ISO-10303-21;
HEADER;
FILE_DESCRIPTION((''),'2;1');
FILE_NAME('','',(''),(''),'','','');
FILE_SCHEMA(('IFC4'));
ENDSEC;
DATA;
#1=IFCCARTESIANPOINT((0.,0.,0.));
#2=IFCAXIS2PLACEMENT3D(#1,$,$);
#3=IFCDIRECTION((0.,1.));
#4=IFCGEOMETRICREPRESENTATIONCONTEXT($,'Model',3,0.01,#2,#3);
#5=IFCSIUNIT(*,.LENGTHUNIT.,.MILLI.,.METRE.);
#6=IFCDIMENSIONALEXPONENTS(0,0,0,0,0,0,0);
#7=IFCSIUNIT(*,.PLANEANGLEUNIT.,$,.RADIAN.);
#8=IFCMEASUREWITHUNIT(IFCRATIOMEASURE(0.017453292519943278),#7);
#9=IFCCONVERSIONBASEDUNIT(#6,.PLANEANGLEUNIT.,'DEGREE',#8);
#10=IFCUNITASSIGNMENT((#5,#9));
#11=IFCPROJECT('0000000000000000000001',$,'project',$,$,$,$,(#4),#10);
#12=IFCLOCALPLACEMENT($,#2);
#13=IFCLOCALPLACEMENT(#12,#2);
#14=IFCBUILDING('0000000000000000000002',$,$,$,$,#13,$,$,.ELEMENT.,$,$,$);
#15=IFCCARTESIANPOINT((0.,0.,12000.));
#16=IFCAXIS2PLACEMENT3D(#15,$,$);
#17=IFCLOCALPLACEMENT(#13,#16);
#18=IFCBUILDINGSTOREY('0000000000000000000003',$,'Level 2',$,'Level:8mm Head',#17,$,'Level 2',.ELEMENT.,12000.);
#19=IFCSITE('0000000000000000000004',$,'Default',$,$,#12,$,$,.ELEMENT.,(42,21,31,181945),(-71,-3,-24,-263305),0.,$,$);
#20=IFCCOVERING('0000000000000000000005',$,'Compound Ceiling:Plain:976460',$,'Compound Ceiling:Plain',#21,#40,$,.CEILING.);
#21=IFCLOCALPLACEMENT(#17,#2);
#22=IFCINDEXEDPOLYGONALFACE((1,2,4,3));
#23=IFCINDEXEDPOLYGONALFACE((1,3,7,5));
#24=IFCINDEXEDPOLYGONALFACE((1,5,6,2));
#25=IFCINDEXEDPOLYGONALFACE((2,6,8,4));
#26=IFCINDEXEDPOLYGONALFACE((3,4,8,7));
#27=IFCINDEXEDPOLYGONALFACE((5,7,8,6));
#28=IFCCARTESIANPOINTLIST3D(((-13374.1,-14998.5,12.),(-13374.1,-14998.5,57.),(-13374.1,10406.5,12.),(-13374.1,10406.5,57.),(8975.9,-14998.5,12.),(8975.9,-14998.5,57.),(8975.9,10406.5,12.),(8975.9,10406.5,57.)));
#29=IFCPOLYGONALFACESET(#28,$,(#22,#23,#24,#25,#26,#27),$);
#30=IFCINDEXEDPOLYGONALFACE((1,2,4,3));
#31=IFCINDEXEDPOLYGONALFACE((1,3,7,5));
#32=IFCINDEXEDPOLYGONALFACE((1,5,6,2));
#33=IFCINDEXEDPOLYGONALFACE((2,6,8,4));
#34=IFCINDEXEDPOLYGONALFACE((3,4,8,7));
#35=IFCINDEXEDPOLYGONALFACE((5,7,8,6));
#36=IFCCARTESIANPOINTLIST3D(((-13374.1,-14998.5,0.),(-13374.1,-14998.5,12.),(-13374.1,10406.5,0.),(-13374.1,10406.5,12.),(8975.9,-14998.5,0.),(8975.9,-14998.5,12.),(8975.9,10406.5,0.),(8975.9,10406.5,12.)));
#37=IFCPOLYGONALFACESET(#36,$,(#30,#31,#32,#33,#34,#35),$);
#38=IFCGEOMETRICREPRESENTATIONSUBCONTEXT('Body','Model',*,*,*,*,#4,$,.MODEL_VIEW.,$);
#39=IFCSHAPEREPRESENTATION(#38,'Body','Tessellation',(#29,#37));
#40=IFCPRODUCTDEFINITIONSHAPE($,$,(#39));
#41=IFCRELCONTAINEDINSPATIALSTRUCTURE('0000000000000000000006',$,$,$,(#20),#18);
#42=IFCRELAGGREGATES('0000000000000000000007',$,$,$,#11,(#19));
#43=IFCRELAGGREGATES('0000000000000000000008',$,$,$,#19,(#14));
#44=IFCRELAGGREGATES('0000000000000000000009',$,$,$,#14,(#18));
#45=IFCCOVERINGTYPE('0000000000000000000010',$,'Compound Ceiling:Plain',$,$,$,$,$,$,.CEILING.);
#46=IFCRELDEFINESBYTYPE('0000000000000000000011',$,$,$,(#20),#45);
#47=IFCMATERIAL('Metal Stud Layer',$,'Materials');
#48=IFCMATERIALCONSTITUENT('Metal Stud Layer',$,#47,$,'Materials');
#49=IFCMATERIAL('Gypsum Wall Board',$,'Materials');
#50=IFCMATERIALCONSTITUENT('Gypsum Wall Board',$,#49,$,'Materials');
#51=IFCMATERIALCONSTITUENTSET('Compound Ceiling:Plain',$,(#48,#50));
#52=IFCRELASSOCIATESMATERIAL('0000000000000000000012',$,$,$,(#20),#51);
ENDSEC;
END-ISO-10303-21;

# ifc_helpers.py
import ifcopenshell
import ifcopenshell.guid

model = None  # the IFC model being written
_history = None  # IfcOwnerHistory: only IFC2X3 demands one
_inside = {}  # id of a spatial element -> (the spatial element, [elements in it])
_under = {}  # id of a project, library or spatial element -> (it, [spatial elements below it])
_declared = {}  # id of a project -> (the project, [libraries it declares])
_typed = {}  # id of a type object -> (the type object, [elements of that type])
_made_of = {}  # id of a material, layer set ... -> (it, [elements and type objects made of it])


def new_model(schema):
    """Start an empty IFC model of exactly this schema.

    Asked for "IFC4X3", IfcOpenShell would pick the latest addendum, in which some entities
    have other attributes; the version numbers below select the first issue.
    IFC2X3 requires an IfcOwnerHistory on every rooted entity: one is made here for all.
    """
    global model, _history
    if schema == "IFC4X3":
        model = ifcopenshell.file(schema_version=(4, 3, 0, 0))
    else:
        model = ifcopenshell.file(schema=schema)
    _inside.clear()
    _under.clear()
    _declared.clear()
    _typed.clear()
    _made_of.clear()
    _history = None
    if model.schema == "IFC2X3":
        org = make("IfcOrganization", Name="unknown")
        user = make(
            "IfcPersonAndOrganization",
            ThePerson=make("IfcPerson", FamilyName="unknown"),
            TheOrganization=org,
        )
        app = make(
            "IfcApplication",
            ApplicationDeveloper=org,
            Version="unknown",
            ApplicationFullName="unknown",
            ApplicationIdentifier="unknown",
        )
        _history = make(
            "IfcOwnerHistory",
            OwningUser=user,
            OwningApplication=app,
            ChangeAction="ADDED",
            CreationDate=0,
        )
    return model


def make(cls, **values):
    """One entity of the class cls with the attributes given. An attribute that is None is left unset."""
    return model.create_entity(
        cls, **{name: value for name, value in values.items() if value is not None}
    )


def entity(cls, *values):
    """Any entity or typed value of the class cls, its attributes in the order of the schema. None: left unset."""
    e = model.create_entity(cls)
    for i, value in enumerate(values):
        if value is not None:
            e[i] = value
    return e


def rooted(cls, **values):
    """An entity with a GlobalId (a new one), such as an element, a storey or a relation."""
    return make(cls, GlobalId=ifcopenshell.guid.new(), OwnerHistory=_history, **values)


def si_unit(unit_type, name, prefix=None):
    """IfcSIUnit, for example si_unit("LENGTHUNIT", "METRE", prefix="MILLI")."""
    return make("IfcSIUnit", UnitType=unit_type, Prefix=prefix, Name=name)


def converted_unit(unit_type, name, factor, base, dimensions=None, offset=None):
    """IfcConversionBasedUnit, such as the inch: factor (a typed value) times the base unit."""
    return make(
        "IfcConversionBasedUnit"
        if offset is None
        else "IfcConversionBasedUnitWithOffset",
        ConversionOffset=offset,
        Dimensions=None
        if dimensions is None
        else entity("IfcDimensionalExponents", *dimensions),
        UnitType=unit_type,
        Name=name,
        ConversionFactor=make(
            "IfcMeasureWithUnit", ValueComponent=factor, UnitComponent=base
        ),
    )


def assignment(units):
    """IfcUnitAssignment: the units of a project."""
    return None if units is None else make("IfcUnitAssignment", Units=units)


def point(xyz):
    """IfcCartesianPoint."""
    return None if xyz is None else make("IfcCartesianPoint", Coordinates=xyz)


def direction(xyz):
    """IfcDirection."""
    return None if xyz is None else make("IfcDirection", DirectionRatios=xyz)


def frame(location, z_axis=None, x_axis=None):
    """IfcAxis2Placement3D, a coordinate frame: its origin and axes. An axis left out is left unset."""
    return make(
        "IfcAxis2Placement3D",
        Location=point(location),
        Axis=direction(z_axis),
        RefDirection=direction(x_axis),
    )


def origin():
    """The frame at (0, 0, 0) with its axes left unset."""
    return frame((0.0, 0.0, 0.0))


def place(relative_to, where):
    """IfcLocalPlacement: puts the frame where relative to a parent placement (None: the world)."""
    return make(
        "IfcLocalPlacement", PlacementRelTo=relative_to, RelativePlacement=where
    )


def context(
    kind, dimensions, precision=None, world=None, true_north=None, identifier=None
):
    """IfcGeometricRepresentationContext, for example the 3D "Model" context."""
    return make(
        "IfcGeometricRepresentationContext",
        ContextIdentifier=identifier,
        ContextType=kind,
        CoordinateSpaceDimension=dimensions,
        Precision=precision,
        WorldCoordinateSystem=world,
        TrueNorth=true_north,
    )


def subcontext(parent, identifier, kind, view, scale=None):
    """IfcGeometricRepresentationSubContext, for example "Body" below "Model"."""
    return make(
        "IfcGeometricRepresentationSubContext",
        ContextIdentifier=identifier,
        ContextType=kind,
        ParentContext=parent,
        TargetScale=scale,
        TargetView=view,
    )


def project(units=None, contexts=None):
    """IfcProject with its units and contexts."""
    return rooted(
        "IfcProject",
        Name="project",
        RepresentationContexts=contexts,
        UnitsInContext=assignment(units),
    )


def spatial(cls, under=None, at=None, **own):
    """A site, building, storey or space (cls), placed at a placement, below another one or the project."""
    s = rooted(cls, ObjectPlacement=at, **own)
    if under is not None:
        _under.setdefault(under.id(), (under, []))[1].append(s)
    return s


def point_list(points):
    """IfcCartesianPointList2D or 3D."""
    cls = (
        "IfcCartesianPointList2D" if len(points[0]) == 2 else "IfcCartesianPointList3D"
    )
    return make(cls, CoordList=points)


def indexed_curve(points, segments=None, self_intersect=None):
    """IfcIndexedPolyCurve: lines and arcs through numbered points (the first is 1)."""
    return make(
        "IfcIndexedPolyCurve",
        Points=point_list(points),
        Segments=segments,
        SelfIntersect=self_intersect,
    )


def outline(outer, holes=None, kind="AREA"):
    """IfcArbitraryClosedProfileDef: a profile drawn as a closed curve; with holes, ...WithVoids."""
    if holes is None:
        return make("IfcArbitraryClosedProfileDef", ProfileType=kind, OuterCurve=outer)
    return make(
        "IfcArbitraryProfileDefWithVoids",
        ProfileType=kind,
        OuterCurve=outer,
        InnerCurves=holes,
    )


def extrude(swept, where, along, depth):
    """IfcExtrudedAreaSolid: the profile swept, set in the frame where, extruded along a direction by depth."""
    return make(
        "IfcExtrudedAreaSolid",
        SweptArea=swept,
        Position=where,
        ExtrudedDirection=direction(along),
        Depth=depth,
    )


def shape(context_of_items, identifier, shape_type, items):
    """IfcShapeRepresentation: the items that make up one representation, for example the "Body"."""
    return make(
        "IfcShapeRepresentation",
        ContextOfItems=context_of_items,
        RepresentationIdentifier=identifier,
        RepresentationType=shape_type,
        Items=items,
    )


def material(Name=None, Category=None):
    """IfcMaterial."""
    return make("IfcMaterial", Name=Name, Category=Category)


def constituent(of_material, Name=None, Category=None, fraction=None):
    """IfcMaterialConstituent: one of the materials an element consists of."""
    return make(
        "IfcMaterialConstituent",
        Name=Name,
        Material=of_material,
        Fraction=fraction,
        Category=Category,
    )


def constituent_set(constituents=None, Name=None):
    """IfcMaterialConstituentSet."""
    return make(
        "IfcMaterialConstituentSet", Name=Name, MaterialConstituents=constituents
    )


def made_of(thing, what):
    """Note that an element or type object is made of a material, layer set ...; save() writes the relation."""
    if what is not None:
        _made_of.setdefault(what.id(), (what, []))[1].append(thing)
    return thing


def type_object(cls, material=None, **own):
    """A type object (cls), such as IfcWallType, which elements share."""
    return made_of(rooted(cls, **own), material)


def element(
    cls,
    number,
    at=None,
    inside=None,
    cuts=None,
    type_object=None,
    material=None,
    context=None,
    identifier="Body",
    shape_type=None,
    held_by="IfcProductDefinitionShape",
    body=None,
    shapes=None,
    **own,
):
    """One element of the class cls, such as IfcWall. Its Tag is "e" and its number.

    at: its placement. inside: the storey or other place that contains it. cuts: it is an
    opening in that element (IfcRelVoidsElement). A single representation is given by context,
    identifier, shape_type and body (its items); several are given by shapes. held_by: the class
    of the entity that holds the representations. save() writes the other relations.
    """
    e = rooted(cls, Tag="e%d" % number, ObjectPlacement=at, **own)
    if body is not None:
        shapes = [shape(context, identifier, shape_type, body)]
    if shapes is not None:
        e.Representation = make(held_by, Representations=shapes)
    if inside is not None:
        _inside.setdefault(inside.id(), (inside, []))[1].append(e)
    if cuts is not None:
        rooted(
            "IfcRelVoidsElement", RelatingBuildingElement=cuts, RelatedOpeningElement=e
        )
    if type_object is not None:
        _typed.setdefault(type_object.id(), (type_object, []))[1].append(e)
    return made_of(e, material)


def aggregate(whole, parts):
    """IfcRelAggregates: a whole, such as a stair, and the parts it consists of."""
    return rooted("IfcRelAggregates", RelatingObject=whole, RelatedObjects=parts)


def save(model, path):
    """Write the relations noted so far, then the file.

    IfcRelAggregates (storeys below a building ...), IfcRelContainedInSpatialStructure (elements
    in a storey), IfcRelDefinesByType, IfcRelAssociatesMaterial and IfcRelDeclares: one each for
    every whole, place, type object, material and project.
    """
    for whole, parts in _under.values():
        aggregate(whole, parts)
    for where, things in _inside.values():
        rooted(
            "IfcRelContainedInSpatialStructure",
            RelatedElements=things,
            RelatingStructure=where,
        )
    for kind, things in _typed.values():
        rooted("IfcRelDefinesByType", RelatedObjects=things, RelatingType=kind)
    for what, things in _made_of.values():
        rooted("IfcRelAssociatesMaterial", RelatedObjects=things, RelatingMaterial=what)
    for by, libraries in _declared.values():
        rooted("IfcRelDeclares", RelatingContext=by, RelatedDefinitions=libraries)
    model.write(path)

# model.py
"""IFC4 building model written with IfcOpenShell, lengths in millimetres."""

from ifc_helpers import new_model, entity, si_unit, converted_unit, direction, frame, origin, place, context, subcontext, project, spatial, indexed_curve, outline, extrude, material, constituent, constituent_set, type_object, element, save


model = new_model("IFC4")

# Units and contexts
model_context = context("Model", 3, precision=0.01, world=origin(), true_north=direction((0.0, 1.0)))
body_context = subcontext(model_context, "Body", "Model", "MODEL_VIEW")
ifc_project = project(units=[si_unit("LENGTHUNIT", "METRE", prefix="MILLI"), converted_unit("PLANEANGLEUNIT", "DEGREE", entity("IfcRatioMeasure", 0.017453292519943278), si_unit("PLANEANGLEUNIT", "RADIAN"), dimensions=[0, 0, 0, 0, 0, 0, 0])], contexts=[model_context])

# Site, building, storey
site_placement = place(None, origin())
site = spatial("IfcSite", under=ifc_project, at=site_placement, Name="Default", CompositionType="ELEMENT", RefLatitude=(42, 21, 31, 181945), RefLongitude=(-71, -3, -24, -263305), RefElevation=0.0)
building_placement = place(site_placement, origin())
building = spatial("IfcBuilding", under=site, at=building_placement, CompositionType="ELEMENT")
storey_placement = place(building_placement, frame((0.0, 0.0, 12000.0)))
storey = spatial("IfcBuildingStorey", under=building, at=storey_placement, Name="Level 2", ObjectType="Level:8mm Head", LongName="Level 2", CompositionType="ELEMENT", Elevation=12000.0)

# Covering
ifc_material_1 = material(Name="Metal Stud Layer", Category="Materials")
ifc_constituent_1 = constituent(ifc_material_1, Name="Metal Stud Layer", Category="Materials")
ifc_material_2 = material(Name="Gypsum Wall Board", Category="Materials")
ifc_constituent_2 = constituent(ifc_material_2, Name="Gypsum Wall Board", Category="Materials")
ifc_constituent_set = constituent_set(constituents=[ifc_constituent_1, ifc_constituent_2], Name="Compound Ceiling:Plain")
covering_type = type_object("IfcCoveringType", Name="Compound Ceiling:Plain", PredefinedType="CEILING")
covering_placement = place(storey_placement, origin())
element("IfcCovering", 1, at=covering_placement, inside=storey, type_object=covering_type, material=ifc_constituent_set, Name="Compound Ceiling:Plain:976460", ObjectType="Compound Ceiling:Plain", PredefinedType="CEILING", context=body_context, shape_type="SweptSolid", body=[
    extrude(outline(indexed_curve([(-12702.5, -11175.0), (12702.5, -11175.0), (12702.5, 11175.0), (-12702.5, 11175.0), (-12702.5, -11175.0)], self_intersect=False)), frame((-2199.1, -2296.0, 12.0), z_axis=(0.0, 0.0, 1.0), x_axis=(0.0, -1.0, 0.0)), (0.0, 0.0, 1.0), 45.0),
    extrude(outline(indexed_curve([(-11175.0, -12702.5), (11175.0, -12702.5), (11175.0, 12702.5), (-11175.0, 12702.5), (-11175.0, -12702.5)], self_intersect=False)), frame((-2199.1, -2296.0, 0.0), z_axis=(0.0, 0.0, 1.0), x_axis=(-1.0, 0.0, 0.0)), (0.0, 0.0, 1.0), 12.0),
])

save(model, "model.ifc")
